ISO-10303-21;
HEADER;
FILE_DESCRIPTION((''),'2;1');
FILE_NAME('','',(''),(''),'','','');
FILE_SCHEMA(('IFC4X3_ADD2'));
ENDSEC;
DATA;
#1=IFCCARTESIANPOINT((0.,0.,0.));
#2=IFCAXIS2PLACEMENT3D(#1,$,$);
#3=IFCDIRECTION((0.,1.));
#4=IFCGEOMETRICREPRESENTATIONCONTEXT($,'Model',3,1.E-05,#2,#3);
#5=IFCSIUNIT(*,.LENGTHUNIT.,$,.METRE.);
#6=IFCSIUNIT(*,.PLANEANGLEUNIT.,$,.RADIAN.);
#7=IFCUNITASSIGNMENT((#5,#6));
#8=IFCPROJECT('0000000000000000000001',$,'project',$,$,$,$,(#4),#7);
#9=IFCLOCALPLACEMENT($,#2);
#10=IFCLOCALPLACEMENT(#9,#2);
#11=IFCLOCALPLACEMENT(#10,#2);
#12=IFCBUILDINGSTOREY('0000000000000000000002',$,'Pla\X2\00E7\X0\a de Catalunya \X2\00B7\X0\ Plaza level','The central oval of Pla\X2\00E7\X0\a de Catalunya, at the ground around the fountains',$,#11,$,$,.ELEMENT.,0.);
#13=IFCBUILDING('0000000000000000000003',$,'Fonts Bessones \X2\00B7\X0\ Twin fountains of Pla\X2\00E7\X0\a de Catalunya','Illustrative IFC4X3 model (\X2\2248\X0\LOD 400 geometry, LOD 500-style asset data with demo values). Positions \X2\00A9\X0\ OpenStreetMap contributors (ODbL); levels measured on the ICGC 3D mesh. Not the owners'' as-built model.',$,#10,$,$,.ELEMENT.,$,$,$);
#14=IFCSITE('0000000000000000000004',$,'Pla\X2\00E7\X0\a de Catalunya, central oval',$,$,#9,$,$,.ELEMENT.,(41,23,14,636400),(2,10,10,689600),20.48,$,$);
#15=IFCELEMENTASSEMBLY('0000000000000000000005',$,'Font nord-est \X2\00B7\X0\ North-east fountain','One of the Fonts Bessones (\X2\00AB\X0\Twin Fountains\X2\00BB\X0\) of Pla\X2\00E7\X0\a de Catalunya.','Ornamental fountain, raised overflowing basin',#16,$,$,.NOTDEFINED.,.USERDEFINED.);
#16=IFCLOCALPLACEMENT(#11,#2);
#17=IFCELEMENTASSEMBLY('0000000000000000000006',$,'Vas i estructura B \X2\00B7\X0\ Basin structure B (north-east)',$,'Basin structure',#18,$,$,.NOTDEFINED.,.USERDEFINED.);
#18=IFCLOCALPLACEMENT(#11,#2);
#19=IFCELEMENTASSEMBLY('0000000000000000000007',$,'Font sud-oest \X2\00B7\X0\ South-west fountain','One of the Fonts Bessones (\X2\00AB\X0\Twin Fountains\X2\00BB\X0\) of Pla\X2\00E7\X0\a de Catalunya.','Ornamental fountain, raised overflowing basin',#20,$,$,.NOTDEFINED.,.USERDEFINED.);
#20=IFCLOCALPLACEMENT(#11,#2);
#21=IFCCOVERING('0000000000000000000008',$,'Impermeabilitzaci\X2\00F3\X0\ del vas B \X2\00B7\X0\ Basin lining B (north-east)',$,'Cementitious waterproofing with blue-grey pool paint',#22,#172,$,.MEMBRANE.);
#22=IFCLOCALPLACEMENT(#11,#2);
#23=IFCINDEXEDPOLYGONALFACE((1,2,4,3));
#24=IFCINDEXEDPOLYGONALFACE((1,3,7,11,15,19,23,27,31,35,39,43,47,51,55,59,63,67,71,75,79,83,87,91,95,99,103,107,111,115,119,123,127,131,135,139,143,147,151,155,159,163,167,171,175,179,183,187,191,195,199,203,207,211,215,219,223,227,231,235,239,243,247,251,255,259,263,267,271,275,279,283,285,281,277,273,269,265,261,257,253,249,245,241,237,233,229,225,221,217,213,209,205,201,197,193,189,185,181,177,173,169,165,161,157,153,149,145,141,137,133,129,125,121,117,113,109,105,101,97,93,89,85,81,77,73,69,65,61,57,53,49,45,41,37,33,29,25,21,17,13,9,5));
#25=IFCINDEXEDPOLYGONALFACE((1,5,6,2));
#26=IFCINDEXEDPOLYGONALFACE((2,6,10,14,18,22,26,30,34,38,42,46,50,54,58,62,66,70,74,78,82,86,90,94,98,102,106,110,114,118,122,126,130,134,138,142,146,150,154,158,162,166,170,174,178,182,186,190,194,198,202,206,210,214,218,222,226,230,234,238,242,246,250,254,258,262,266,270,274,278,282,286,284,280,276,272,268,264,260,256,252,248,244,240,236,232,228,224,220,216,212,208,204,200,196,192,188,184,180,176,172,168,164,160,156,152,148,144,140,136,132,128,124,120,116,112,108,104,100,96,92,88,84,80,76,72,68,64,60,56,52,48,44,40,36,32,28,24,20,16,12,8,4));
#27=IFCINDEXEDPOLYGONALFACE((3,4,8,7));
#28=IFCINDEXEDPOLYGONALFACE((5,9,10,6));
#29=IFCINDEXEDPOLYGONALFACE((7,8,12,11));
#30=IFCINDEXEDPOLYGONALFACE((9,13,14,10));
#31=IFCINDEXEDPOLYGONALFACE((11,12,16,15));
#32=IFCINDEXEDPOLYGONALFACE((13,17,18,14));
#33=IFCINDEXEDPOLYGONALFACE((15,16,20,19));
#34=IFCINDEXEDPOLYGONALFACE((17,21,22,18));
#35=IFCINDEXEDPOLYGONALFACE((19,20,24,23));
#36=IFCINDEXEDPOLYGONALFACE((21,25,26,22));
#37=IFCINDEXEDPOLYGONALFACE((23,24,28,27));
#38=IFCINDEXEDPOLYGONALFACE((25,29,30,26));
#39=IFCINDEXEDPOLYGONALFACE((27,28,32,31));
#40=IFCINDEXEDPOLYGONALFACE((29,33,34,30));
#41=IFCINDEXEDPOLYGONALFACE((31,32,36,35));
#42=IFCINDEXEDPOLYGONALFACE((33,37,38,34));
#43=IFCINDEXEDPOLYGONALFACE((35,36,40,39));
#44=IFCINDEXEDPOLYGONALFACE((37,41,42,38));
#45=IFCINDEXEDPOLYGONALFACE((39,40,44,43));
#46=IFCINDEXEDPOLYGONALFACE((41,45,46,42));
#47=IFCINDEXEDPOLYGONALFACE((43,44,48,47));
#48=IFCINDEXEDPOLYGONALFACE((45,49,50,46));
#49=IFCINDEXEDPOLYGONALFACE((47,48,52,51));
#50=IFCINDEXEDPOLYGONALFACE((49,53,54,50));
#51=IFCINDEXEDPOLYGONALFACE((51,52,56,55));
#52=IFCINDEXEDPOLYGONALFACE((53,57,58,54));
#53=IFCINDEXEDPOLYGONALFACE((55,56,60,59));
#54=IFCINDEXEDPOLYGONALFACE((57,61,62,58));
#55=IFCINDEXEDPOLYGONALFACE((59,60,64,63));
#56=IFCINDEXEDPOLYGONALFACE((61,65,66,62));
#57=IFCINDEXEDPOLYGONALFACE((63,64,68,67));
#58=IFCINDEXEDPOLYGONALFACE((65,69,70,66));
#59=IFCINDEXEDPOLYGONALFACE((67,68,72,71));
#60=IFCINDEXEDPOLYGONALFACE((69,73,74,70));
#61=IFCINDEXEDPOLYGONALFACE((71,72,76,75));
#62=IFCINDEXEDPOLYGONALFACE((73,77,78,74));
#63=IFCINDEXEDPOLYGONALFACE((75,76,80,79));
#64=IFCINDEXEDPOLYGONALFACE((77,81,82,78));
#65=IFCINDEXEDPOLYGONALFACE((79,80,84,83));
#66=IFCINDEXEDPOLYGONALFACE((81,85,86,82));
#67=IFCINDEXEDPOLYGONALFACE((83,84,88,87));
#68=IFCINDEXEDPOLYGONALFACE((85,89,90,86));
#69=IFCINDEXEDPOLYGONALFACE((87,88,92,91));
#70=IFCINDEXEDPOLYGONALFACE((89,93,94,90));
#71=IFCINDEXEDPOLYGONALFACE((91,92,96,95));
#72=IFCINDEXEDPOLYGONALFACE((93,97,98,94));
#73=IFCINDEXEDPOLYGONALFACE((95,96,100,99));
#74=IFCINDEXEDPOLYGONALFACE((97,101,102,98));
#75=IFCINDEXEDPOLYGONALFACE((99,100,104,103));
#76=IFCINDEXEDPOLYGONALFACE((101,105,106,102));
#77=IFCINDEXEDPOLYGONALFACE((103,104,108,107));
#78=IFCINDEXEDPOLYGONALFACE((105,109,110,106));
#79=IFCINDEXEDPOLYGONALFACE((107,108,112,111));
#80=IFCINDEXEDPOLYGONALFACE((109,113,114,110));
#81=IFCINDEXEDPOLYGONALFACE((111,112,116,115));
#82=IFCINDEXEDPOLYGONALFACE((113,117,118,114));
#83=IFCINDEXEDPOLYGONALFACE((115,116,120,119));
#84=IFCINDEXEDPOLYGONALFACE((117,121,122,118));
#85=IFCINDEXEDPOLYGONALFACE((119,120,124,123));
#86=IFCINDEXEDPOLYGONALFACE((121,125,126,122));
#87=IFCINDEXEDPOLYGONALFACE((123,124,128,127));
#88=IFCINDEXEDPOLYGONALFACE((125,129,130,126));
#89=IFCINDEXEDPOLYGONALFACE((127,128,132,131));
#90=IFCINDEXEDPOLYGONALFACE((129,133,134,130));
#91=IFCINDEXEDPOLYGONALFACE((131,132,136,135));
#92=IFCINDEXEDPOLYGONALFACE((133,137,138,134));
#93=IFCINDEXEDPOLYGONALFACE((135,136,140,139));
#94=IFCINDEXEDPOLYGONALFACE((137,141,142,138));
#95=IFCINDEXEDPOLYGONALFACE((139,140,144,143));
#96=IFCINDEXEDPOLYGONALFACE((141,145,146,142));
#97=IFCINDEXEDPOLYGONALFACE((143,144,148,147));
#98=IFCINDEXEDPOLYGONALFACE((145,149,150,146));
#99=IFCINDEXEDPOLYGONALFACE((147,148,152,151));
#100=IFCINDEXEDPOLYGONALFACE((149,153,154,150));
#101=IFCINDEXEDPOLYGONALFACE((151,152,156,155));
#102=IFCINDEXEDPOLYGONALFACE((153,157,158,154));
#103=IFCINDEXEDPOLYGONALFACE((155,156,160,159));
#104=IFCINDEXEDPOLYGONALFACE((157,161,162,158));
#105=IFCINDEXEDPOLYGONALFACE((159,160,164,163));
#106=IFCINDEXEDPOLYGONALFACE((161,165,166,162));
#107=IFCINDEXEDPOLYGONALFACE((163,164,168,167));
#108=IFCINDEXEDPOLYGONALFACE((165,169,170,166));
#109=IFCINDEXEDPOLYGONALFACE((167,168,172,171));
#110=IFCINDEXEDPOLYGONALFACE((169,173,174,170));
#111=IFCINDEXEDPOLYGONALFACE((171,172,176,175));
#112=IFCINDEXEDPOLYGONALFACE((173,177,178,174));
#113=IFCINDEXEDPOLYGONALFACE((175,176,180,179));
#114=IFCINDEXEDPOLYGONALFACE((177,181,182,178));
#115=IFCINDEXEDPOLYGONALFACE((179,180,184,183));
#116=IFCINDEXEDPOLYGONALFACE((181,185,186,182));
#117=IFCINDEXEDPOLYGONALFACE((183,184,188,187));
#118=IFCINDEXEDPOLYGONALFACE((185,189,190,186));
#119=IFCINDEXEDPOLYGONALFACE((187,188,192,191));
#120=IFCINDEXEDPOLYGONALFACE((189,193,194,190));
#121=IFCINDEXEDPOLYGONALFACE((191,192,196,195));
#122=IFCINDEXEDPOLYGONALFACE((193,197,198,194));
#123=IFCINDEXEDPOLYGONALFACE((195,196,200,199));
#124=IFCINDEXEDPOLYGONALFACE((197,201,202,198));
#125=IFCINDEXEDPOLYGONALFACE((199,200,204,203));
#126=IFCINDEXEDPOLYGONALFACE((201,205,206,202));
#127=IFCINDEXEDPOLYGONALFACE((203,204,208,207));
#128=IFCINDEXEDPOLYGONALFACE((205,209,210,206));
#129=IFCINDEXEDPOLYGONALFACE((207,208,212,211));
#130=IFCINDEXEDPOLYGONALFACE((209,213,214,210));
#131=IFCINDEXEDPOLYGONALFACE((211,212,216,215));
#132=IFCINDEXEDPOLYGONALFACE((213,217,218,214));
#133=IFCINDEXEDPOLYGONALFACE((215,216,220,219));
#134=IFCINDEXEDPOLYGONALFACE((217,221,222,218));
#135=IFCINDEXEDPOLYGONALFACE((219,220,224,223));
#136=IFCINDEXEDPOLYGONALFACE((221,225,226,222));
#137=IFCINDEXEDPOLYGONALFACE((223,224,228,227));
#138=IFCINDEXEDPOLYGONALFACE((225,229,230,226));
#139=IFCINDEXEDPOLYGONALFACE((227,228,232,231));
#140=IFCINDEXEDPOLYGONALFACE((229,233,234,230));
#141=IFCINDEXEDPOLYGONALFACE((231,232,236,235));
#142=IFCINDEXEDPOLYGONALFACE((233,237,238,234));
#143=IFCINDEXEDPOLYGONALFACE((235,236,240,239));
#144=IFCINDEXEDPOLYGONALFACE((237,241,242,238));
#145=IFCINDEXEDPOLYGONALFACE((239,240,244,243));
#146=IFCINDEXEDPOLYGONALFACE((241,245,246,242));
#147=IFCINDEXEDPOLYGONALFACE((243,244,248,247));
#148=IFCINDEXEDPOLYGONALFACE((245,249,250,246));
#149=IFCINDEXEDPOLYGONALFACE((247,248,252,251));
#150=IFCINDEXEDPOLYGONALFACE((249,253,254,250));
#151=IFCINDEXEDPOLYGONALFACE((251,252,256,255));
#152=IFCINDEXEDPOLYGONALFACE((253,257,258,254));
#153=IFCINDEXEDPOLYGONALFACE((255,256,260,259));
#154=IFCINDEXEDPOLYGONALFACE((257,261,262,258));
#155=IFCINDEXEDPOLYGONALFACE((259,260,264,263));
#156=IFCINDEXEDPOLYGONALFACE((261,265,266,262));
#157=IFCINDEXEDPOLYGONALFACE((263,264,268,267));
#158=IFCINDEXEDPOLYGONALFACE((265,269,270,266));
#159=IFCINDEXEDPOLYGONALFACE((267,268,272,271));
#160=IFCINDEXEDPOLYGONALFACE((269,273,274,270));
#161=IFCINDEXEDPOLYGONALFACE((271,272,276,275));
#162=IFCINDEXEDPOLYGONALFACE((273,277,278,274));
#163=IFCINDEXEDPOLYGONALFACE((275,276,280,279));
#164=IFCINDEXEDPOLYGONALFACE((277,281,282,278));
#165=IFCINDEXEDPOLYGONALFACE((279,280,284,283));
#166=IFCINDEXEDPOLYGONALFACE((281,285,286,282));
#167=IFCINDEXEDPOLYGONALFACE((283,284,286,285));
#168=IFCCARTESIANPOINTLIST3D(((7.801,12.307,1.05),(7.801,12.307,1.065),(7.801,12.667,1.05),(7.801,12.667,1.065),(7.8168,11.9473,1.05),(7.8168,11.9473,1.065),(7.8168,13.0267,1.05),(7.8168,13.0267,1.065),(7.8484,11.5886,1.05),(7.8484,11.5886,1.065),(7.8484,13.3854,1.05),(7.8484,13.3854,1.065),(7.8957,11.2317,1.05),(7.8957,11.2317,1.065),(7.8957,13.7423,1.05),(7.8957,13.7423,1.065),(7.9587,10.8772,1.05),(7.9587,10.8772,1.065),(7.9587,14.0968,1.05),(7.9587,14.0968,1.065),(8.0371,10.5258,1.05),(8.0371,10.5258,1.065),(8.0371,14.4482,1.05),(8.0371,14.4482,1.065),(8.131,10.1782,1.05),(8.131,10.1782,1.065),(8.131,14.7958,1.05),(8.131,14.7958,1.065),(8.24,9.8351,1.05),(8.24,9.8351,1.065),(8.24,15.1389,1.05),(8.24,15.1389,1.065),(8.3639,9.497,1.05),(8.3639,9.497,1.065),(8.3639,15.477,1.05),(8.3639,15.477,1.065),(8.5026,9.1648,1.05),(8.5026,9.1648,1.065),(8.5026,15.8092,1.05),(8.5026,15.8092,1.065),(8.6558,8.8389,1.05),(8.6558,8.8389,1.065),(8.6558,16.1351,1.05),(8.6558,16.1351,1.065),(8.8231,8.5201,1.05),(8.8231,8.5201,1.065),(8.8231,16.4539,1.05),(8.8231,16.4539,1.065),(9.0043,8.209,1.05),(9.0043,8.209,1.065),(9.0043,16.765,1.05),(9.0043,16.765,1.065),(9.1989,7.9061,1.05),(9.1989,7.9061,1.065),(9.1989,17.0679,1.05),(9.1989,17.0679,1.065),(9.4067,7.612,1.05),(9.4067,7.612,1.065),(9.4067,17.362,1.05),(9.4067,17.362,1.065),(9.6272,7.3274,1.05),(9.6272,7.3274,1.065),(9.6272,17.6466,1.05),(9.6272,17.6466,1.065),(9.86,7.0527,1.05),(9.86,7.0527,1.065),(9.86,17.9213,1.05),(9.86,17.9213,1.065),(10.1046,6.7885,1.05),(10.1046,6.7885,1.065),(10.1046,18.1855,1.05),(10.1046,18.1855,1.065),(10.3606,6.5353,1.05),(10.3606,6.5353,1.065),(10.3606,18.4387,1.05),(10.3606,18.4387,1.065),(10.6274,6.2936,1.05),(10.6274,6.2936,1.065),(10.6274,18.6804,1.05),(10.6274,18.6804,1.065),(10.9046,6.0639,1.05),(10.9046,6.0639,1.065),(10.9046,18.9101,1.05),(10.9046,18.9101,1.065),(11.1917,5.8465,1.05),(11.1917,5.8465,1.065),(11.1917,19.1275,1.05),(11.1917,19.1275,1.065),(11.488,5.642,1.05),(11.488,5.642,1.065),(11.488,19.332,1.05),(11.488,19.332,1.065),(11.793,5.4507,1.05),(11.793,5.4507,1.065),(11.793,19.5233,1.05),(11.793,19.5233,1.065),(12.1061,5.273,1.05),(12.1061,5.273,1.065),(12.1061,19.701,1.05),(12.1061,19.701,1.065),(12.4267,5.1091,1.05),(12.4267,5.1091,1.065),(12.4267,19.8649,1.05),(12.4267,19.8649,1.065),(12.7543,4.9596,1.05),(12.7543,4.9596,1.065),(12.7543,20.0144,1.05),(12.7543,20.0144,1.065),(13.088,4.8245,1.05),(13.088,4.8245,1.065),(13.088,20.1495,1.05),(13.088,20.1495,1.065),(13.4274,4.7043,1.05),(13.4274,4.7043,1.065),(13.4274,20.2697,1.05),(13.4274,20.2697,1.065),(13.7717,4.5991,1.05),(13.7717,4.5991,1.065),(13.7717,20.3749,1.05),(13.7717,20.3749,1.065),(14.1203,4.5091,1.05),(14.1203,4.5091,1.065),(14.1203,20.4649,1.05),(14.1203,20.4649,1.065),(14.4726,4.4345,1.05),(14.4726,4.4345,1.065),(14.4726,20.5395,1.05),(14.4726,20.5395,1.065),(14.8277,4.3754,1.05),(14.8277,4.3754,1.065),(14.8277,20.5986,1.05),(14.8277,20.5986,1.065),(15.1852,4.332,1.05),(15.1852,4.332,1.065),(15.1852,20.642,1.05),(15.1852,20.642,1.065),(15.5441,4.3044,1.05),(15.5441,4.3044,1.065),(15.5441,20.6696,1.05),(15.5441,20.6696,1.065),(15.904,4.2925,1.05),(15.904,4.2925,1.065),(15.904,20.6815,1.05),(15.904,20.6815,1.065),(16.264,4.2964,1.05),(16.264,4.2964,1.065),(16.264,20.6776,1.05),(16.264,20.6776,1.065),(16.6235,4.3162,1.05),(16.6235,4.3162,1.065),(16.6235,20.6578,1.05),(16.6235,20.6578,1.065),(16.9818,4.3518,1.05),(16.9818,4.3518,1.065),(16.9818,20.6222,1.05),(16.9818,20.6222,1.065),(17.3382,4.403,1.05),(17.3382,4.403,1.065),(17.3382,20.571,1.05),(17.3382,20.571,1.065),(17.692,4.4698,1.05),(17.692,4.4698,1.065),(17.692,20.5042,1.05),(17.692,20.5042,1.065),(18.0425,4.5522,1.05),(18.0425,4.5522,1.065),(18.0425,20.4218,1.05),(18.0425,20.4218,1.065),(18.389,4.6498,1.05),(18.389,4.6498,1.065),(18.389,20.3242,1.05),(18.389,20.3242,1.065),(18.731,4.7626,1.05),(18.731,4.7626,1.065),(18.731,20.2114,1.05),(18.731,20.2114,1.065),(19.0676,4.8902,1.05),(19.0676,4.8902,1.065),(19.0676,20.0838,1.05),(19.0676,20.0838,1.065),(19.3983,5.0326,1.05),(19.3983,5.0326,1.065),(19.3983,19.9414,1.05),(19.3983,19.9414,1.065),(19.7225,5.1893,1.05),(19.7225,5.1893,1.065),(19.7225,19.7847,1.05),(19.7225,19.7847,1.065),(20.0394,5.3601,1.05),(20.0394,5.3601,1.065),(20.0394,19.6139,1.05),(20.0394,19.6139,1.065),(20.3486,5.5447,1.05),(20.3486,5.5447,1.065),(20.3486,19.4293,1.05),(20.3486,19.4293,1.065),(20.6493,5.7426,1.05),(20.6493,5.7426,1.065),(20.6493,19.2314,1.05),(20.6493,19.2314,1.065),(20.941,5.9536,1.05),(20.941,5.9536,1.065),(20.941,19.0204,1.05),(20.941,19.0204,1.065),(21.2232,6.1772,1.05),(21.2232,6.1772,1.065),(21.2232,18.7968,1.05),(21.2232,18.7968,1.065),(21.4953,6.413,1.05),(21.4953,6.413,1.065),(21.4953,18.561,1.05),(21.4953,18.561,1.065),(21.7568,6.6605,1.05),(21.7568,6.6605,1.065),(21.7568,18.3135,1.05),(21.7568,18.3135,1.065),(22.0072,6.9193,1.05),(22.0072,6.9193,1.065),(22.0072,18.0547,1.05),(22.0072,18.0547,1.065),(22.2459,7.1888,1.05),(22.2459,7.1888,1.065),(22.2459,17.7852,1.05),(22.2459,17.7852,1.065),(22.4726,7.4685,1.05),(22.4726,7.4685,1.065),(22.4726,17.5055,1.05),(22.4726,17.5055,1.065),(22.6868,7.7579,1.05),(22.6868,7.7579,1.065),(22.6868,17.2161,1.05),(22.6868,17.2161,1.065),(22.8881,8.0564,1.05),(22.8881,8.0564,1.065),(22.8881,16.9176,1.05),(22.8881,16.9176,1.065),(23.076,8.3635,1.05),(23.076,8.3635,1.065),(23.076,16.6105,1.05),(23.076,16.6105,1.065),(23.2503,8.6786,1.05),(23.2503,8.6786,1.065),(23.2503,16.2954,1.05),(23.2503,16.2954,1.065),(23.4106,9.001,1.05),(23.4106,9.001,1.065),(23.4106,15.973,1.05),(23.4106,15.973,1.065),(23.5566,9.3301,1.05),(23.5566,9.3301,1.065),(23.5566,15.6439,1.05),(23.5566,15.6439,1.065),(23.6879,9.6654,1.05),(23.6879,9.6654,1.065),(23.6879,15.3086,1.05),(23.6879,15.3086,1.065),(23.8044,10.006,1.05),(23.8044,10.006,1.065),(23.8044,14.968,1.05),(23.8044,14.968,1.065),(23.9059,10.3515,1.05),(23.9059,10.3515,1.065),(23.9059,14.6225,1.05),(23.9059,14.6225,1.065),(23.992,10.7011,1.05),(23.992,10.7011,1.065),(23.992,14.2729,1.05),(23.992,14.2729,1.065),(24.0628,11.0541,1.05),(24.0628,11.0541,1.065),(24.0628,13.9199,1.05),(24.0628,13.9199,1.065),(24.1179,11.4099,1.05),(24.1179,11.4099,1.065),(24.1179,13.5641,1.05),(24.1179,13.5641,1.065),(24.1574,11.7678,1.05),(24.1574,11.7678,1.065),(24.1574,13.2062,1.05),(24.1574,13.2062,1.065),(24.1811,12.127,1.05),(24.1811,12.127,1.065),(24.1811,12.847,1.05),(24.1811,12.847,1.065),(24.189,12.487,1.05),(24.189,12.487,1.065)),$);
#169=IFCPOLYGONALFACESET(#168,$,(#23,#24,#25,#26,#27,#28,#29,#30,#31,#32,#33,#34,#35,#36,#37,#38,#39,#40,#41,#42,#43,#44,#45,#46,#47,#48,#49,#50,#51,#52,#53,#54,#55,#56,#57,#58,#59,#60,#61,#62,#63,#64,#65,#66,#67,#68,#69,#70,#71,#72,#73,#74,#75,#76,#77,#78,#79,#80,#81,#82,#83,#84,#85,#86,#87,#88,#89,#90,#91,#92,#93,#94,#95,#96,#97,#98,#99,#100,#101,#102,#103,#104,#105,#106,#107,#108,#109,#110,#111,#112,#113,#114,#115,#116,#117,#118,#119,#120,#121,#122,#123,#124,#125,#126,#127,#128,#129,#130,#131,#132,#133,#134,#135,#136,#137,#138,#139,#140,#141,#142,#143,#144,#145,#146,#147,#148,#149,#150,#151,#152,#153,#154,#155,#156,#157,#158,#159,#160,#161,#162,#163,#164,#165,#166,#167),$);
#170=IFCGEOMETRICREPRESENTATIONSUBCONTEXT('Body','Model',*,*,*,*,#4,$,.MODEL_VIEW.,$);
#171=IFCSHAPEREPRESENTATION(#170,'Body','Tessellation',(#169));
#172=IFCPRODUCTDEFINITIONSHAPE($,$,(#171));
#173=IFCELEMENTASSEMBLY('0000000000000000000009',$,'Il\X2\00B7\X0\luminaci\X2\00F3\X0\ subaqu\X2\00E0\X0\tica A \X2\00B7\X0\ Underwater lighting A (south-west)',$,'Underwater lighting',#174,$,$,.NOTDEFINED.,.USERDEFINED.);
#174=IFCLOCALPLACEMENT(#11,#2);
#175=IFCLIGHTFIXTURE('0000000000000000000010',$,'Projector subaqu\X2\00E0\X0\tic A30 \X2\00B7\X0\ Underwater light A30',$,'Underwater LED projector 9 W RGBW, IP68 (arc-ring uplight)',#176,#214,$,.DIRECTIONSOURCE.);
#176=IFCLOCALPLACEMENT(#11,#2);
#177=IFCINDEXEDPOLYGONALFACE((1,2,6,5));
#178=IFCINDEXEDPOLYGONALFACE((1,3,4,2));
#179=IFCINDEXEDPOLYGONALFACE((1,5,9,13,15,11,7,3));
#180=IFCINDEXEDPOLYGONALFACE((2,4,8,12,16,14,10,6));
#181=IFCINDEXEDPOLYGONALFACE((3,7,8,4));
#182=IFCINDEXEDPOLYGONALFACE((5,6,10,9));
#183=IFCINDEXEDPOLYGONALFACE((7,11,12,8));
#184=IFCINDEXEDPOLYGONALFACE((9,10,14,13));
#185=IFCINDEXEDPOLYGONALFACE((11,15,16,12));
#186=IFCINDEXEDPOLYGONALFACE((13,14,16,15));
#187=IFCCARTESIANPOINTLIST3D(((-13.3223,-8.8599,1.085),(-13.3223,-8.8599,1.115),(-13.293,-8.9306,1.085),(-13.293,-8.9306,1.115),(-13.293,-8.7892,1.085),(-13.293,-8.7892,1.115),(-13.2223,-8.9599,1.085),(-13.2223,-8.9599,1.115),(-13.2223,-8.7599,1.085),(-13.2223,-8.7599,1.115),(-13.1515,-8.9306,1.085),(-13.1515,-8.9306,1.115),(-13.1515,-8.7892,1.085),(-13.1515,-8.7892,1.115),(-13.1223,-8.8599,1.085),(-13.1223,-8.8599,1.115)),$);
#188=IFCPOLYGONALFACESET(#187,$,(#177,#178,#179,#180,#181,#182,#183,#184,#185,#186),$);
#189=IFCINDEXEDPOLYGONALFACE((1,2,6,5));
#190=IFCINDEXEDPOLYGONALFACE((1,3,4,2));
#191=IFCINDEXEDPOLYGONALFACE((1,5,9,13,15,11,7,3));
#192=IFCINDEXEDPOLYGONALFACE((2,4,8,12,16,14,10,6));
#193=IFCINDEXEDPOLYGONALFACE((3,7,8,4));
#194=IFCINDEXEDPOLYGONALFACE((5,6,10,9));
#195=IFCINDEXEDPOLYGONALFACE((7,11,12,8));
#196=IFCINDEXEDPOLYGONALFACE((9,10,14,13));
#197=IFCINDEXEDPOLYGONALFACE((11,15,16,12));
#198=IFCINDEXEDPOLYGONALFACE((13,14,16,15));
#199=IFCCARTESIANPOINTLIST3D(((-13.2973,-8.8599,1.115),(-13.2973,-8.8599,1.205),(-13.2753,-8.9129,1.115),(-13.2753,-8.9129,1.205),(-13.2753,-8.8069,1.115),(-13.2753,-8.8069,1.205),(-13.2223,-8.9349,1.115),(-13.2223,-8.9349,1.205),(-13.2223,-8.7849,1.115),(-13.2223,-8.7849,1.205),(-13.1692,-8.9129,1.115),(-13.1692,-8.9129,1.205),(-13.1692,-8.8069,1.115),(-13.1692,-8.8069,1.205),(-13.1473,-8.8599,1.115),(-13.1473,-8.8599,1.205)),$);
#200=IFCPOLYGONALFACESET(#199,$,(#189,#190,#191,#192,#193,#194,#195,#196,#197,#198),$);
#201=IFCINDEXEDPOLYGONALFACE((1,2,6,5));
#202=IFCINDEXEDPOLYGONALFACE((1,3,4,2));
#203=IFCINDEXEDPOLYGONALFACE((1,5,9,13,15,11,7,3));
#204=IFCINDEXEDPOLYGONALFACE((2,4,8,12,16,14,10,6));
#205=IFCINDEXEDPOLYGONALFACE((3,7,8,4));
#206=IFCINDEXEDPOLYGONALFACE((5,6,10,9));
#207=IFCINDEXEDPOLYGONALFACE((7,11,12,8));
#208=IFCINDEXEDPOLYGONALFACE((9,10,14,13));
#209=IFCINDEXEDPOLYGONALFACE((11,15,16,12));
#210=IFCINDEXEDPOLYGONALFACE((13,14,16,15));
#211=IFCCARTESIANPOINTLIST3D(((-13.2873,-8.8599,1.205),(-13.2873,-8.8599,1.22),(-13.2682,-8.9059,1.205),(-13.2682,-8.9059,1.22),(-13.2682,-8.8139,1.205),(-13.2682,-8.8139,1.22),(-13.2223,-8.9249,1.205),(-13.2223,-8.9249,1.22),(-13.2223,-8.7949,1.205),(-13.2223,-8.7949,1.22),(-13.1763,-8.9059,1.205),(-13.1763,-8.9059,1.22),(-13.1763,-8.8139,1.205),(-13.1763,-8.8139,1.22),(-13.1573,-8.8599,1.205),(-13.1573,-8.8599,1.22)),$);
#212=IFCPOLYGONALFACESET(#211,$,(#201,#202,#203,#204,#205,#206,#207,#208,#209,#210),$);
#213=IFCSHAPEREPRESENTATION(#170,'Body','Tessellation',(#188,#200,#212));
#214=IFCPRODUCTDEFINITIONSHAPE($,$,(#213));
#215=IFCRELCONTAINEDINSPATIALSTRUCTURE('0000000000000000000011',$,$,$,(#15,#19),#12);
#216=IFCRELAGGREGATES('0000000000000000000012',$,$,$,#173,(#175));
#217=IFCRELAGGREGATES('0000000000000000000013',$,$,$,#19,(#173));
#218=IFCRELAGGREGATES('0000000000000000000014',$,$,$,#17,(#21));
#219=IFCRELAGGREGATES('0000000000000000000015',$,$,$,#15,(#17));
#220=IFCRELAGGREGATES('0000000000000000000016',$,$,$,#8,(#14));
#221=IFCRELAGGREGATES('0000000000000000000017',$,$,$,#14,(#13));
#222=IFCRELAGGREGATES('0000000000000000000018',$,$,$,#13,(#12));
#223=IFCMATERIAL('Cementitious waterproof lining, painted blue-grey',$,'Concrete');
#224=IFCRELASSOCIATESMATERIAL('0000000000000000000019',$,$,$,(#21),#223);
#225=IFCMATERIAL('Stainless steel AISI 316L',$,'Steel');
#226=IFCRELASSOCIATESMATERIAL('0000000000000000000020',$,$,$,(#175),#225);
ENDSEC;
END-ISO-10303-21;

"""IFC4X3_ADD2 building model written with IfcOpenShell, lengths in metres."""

from ifc_helpers import new_model, si_unit, direction, frame, origin, origin_2d_with_axis, place, context, subcontext, project, spatial, polyline, circle, outline, extrude, material, element, aggregate, save


model = new_model("IFC4X3_ADD2")

# Units and contexts
model_context = context("Model", 3, precision=1e-05, world=origin(), true_north=direction((0.0, 1.0)))
body_context = subcontext(model_context, "Body", "Model", "MODEL_VIEW")
ifc_project = project(units=[si_unit("LENGTHUNIT", "METRE"), si_unit("PLANEANGLEUNIT", "RADIAN")], contexts=[model_context])

# Site, building, storey
site_placement = place(None, origin())
site = spatial("IfcSite", under=ifc_project, at=site_placement, Name="Plaça de Catalunya, central oval", CompositionType="ELEMENT", RefLatitude=(41, 23, 14, 636400), RefLongitude=(2, 10, 10, 689600), RefElevation=20.48)
building_placement = place(site_placement, origin())
building = spatial("IfcBuilding", under=site, at=building_placement, Name="Fonts Bessones · Twin fountains of Plaça de Catalunya", Description="Illustrative IFC4X3 model (≈LOD 400 geometry, LOD 500-style asset data with demo values). Positions © OpenStreetMap contributors (ODbL); levels measured on the ICGC 3D mesh. Not the owners' as-built model.", CompositionType="ELEMENT")
storey_placement = place(building_placement, origin())
storey = spatial("IfcBuildingStorey", under=building, at=storey_placement, Name="Plaça de Catalunya · Plaza level", Description="The central oval of Plaça de Catalunya, at the ground around the fountains", CompositionType="ELEMENT", Elevation=0.0)

# Element assemblies
assembly_1_placement = place(building_placement, origin())
assembly_1 = element("IfcElementAssembly", 1, at=assembly_1_placement, inside=storey, Name="Font nord-est · North-east fountain", Description="One of the Fonts Bessones («Twin Fountains») of Plaça de Catalunya.", ObjectType="Ornamental fountain, raised overflowing basin", AssemblyPlace="NOTDEFINED", PredefinedType="USERDEFINED")
assembly_2_placement = place(building_placement, origin())
assembly_2 = element("IfcElementAssembly", 2, at=assembly_2_placement, Name="Vas i estructura B · Basin structure B (north-east)", ObjectType="Basin structure", AssemblyPlace="NOTDEFINED", PredefinedType="USERDEFINED")

# Element assembly
assembly_3_placement = place(building_placement, origin())
assembly_3 = element("IfcElementAssembly", 3, at=assembly_3_placement, inside=storey, Name="Font sud-oest · South-west fountain", Description="One of the Fonts Bessones («Twin Fountains») of Plaça de Catalunya.", ObjectType="Ornamental fountain, raised overflowing basin", AssemblyPlace="NOTDEFINED", PredefinedType="USERDEFINED")

# Covering
ifc_material_1 = material(Name="Cementitious waterproof lining, painted blue-grey", Category="Concrete")
covering_1_placement = place(building_placement, origin())
covering_1 = element("IfcCovering", 4, at=covering_1_placement, material=ifc_material_1, Name="Impermeabilització del vas B · Basin lining B (north-east)", ObjectType="Cementitious waterproofing with blue-grey pool paint", PredefinedType="MEMBRANE", context=body_context, shape_type="SweptSolid", body=[
    extrude(circle(Radius=8.195, at=origin_2d_with_axis()), frame((15.994, 12.487, 1.05)), (0.0, 0.0, 1.0), 0.015),
])

# Element assembly, light fixture
assembly_4_placement = place(building_placement, origin())
assembly_4 = element("IfcElementAssembly", 5, at=assembly_4_placement, Name="Il·luminació subaquàtica A · Underwater lighting A (south-west)", ObjectType="Underwater lighting", AssemblyPlace="NOTDEFINED", PredefinedType="USERDEFINED")
ifc_material_2 = material(Name="Stainless steel AISI 316L", Category="Steel")
light_fixture_1_placement = place(building_placement, origin())
light_fixture_1 = element("IfcLightFixture", 6, at=light_fixture_1_placement, material=ifc_material_2, Name="Projector subaquàtic A30 · Underwater light A30", ObjectType="Underwater LED projector 9 W RGBW, IP68 (arc-ring uplight)", PredefinedType="DIRECTIONSOURCE", context=body_context, shape_type="SweptSolid", body=[
    extrude(outline(polyline([(-13.1223, -8.8599), (-13.1515, -8.7892), (-13.2223, -8.7599), (-13.293, -8.7892), (-13.3223, -8.8599), (-13.293, -8.9306), (-13.2223, -8.9599), (-13.1515, -8.9306), (-13.1223, -8.8599)])), frame((0.0, 0.0, 1.085)), (0.0, 0.0, 1.0), 0.03),
    extrude(outline(polyline([(-13.1473, -8.8599), (-13.1692, -8.8069), (-13.2223, -8.7849), (-13.2753, -8.8069), (-13.2973, -8.8599), (-13.2753, -8.9129), (-13.2223, -8.9349), (-13.1692, -8.9129), (-13.1473, -8.8599)])), frame((0.0, 0.0, 1.115)), (0.0, 0.0, 1.0), 0.09),
    extrude(outline(polyline([(-13.1573, -8.8599), (-13.1763, -8.8139), (-13.2223, -8.7949), (-13.2682, -8.8139), (-13.2873, -8.8599), (-13.2682, -8.9059), (-13.2223, -8.9249), (-13.1763, -8.9059), (-13.1573, -8.8599)])), frame((0.0, 0.0, 1.205)), (0.0, 0.0, 1.0), 0.015),
])
aggregate(assembly_4, [light_fixture_1])

aggregate(assembly_3, [assembly_4])

aggregate(assembly_2, [covering_1])

aggregate(assembly_1, [assembly_2])

save(model, "model.ifc")
